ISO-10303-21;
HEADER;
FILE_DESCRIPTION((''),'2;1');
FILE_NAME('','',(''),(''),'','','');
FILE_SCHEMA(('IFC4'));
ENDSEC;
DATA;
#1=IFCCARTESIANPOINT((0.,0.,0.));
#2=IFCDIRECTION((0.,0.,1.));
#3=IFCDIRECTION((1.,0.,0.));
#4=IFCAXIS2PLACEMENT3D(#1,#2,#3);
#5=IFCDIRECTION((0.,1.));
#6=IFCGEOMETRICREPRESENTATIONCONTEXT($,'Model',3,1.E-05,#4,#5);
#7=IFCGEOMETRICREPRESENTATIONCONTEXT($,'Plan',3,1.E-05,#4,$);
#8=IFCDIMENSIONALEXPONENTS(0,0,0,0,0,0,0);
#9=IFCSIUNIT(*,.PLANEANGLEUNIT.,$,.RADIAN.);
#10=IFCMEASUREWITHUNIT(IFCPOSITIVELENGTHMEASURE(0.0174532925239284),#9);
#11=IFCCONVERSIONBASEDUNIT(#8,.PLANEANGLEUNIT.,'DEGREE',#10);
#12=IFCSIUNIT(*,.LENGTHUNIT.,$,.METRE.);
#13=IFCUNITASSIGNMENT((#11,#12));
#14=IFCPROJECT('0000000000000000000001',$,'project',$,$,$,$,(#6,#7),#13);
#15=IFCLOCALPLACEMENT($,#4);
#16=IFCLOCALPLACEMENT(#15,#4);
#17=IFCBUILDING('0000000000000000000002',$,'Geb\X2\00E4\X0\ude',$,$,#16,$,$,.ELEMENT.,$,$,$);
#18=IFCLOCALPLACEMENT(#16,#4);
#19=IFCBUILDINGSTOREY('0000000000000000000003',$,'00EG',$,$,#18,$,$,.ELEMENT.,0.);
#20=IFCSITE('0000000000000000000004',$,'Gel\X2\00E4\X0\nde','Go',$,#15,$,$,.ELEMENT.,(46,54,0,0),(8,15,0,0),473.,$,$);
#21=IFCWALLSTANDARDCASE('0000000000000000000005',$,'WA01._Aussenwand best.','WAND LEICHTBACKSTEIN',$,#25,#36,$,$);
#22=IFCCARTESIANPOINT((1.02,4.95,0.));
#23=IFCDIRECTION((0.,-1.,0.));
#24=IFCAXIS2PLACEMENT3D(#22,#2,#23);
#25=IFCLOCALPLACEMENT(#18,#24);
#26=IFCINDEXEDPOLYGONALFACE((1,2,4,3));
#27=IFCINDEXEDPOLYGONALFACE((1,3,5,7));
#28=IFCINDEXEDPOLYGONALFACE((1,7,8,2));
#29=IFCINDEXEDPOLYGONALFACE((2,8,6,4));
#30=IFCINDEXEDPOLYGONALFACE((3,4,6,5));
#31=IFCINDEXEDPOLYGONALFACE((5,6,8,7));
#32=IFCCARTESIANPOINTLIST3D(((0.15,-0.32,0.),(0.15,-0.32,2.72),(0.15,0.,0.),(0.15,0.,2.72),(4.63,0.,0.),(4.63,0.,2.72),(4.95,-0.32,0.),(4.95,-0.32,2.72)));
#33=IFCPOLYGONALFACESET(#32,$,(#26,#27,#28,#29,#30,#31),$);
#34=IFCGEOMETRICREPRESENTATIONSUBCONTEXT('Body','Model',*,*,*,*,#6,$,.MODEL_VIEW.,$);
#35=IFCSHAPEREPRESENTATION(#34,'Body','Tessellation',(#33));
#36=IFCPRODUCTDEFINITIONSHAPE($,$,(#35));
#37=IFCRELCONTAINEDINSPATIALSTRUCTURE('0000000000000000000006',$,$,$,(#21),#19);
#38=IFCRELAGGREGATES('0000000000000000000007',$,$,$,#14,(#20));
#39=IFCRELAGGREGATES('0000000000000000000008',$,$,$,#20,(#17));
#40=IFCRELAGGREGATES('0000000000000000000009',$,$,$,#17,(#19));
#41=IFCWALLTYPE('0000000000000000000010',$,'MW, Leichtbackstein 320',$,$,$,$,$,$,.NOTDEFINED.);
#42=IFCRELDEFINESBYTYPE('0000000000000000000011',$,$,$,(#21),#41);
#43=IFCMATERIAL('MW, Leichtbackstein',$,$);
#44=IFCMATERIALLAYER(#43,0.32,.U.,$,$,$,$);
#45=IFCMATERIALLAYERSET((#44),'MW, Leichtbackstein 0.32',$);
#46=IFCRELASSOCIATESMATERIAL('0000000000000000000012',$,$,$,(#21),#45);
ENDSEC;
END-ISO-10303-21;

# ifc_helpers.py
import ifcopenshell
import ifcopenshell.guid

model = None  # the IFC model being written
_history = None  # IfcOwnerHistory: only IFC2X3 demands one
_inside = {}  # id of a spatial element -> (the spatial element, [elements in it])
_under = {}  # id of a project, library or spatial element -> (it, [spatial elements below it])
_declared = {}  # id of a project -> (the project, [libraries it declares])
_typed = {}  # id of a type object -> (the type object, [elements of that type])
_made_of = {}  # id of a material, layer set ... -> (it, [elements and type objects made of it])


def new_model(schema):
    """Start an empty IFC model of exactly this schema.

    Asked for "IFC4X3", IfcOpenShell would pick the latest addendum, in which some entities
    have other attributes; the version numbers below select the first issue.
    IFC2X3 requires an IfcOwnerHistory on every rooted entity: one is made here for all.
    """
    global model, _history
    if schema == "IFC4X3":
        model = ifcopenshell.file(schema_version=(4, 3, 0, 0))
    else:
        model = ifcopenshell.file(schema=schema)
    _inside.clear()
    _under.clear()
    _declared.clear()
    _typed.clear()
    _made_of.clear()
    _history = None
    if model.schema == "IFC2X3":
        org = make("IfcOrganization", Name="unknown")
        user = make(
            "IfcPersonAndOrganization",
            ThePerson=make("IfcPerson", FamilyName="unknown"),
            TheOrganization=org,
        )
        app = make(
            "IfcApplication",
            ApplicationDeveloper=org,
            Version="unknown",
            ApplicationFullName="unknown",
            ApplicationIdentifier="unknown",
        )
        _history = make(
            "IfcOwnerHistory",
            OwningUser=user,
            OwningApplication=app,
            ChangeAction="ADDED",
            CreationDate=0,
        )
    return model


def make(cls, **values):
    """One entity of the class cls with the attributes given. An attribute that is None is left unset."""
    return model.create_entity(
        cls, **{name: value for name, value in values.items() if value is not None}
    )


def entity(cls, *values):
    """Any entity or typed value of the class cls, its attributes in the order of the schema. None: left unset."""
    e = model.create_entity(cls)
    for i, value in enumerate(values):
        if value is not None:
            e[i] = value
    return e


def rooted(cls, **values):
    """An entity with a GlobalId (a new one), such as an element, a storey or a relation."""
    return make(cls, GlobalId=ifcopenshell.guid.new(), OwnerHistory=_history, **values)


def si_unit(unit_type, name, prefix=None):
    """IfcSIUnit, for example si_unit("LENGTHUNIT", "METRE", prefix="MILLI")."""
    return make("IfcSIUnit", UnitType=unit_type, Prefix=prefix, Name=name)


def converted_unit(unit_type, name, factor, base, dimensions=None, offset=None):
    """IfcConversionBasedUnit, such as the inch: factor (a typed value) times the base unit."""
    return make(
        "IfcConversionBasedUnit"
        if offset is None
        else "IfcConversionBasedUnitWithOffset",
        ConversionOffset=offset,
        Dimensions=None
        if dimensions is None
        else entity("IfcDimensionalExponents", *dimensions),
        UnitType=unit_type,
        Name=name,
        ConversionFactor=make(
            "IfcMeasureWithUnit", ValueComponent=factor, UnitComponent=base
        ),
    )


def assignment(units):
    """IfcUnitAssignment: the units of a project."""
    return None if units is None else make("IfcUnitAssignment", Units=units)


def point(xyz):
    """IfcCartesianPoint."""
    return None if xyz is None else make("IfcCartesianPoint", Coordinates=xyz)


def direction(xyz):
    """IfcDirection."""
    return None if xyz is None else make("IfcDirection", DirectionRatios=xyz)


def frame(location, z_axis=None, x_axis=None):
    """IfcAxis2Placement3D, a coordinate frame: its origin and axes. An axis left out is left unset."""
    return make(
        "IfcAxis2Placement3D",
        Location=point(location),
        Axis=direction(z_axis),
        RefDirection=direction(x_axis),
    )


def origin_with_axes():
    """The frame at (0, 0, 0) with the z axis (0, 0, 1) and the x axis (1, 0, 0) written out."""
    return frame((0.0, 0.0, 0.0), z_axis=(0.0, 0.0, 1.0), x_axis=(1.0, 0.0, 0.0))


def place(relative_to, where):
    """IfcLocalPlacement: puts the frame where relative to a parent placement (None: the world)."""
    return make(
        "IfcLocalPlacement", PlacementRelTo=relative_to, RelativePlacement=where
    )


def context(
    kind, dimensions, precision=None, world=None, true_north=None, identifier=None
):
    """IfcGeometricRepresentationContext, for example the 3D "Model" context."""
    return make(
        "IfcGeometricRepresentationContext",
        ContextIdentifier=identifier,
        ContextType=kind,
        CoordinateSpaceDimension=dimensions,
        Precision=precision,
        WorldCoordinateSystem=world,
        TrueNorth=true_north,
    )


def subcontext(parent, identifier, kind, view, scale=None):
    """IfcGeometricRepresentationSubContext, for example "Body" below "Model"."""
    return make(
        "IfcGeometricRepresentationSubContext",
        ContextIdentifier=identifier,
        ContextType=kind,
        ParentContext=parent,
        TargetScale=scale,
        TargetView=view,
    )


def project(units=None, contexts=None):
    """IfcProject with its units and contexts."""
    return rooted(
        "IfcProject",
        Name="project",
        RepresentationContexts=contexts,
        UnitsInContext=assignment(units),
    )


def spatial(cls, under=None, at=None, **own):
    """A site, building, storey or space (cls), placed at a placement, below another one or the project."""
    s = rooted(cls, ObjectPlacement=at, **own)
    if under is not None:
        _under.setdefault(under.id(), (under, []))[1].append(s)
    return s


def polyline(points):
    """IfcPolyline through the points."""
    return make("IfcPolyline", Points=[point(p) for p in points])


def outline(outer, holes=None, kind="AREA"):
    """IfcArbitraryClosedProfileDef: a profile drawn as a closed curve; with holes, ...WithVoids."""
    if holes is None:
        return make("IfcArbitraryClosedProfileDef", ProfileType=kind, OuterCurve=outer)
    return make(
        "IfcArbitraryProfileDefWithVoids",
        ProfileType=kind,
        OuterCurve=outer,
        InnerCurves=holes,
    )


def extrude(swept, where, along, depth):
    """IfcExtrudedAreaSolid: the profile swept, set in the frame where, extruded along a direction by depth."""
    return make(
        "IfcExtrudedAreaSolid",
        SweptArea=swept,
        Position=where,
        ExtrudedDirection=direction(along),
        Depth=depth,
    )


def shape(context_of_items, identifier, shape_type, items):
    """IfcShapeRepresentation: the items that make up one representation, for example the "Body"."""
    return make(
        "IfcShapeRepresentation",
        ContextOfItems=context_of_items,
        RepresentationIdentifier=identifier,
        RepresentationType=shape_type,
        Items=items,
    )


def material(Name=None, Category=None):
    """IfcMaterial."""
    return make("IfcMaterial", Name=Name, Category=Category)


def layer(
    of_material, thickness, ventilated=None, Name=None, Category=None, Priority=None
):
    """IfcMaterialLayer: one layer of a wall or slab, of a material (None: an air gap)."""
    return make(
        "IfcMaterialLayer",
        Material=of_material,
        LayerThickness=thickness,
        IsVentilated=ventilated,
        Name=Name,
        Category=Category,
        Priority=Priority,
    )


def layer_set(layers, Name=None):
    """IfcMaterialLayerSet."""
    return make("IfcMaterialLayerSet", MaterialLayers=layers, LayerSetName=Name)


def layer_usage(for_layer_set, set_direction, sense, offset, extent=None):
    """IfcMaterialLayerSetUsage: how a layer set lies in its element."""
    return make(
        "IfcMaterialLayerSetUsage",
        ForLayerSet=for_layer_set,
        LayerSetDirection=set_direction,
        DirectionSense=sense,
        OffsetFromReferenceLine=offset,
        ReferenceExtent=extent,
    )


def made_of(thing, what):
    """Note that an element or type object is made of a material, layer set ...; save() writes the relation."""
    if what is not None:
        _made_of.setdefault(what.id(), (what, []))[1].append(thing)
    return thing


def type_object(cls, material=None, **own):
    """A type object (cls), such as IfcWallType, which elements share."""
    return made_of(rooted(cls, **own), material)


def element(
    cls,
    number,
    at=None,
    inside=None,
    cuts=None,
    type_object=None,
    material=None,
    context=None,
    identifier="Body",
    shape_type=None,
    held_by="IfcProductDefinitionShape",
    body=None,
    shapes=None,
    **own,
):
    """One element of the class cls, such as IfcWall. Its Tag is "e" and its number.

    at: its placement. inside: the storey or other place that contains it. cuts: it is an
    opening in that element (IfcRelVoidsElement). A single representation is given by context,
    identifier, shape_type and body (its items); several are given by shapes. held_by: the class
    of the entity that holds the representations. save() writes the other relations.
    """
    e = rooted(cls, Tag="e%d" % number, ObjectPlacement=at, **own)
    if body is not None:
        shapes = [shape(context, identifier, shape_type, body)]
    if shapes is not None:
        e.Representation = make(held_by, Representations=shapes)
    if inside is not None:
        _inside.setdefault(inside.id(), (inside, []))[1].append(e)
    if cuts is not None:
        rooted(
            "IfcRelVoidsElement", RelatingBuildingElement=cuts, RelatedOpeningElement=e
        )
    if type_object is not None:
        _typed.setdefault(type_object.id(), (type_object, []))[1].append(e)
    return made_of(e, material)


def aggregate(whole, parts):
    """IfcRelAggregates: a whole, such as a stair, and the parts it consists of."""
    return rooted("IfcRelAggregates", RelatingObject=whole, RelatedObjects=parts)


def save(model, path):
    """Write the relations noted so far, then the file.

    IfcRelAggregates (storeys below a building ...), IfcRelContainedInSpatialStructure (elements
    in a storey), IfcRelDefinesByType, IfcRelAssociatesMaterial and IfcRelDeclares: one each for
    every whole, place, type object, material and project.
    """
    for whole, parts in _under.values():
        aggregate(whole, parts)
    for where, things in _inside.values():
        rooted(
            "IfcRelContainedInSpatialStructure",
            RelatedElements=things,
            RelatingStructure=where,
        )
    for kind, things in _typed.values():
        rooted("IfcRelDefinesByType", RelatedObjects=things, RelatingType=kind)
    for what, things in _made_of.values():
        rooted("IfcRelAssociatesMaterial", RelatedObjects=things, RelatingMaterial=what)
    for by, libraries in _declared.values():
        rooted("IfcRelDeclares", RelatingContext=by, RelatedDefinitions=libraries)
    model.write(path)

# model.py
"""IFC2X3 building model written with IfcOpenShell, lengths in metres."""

from ifc_helpers import new_model, entity, si_unit, converted_unit, direction, frame, origin_with_axes, place, context, subcontext, project, spatial, polyline, outline, extrude, material, layer, layer_set, layer_usage, type_object, element, save


model = new_model("IFC2X3")

# Units and contexts
model_context = context("Model", 3, precision=1e-05, world=origin_with_axes(), true_north=direction((0.0, 1.0)))
plan_context = context("Plan", 3, precision=1e-05, world=origin_with_axes())
body_context = subcontext(model_context, "Body", "Model", "MODEL_VIEW")
ifc_project = project(units=[converted_unit("PLANEANGLEUNIT", "DEGREE", entity("IfcPositiveLengthMeasure", 0.0174532925239284), si_unit("PLANEANGLEUNIT", "RADIAN"), dimensions=[0, 0, 0, 0, 0, 0, 0]), si_unit("LENGTHUNIT", "METRE")], contexts=[model_context, plan_context])

# Site, building, storey
site_placement = place(None, origin_with_axes())
site = spatial("IfcSite", under=ifc_project, at=site_placement, Name="Gelände", Description="Go", CompositionType="ELEMENT", RefLatitude=(46, 54, 0, 0), RefLongitude=(8, 15, 0, 0), RefElevation=473.0)
building_placement = place(site_placement, origin_with_axes())
building = spatial("IfcBuilding", under=site, at=building_placement, Name="Gebäude", CompositionType="ELEMENT")
storey_placement = place(building_placement, origin_with_axes())
storey = spatial("IfcBuildingStorey", under=building, at=storey_placement, Name="00EG", CompositionType="ELEMENT", Elevation=0.0)

# Wall
ifc_material_1 = material(Name="MW, Leichtbackstein")
ifc_layer_1 = layer(ifc_material_1, 0.32, ventilated="UNKNOWN")
ifc_layer_set_1 = layer_set([ifc_layer_1], Name="MW, Leichtbackstein 0.32")
wall_type_1 = type_object("IfcWallType", Name="MW, Leichtbackstein 320", PredefinedType="NOTDEFINED")
ifc_layer_usage_1 = layer_usage(ifc_layer_set_1, "AXIS2", "POSITIVE", -0.32)
wall_1_placement = place(storey_placement, frame((1.02, 4.95, 0.0), z_axis=(0.0, 0.0, 1.0), x_axis=(0.0, -1.0, 0.0)))
element("IfcWallStandardCase", 1, at=wall_1_placement, inside=storey, type_object=wall_type_1, material=ifc_layer_usage_1, Name="WA01._Aussenwand best.", Description="WAND LEICHTBACKSTEIN", context=body_context, shape_type="SweptSolid", body=[
    extrude(outline(polyline([(0.15, -0.32), (4.95, -0.32), (4.63, 0.0), (0.15, 0.0), (0.15, -0.32)])), origin_with_axes(), (0.0, 0.0, 1.0), 2.72),
])

save(model, "model.ifc")
